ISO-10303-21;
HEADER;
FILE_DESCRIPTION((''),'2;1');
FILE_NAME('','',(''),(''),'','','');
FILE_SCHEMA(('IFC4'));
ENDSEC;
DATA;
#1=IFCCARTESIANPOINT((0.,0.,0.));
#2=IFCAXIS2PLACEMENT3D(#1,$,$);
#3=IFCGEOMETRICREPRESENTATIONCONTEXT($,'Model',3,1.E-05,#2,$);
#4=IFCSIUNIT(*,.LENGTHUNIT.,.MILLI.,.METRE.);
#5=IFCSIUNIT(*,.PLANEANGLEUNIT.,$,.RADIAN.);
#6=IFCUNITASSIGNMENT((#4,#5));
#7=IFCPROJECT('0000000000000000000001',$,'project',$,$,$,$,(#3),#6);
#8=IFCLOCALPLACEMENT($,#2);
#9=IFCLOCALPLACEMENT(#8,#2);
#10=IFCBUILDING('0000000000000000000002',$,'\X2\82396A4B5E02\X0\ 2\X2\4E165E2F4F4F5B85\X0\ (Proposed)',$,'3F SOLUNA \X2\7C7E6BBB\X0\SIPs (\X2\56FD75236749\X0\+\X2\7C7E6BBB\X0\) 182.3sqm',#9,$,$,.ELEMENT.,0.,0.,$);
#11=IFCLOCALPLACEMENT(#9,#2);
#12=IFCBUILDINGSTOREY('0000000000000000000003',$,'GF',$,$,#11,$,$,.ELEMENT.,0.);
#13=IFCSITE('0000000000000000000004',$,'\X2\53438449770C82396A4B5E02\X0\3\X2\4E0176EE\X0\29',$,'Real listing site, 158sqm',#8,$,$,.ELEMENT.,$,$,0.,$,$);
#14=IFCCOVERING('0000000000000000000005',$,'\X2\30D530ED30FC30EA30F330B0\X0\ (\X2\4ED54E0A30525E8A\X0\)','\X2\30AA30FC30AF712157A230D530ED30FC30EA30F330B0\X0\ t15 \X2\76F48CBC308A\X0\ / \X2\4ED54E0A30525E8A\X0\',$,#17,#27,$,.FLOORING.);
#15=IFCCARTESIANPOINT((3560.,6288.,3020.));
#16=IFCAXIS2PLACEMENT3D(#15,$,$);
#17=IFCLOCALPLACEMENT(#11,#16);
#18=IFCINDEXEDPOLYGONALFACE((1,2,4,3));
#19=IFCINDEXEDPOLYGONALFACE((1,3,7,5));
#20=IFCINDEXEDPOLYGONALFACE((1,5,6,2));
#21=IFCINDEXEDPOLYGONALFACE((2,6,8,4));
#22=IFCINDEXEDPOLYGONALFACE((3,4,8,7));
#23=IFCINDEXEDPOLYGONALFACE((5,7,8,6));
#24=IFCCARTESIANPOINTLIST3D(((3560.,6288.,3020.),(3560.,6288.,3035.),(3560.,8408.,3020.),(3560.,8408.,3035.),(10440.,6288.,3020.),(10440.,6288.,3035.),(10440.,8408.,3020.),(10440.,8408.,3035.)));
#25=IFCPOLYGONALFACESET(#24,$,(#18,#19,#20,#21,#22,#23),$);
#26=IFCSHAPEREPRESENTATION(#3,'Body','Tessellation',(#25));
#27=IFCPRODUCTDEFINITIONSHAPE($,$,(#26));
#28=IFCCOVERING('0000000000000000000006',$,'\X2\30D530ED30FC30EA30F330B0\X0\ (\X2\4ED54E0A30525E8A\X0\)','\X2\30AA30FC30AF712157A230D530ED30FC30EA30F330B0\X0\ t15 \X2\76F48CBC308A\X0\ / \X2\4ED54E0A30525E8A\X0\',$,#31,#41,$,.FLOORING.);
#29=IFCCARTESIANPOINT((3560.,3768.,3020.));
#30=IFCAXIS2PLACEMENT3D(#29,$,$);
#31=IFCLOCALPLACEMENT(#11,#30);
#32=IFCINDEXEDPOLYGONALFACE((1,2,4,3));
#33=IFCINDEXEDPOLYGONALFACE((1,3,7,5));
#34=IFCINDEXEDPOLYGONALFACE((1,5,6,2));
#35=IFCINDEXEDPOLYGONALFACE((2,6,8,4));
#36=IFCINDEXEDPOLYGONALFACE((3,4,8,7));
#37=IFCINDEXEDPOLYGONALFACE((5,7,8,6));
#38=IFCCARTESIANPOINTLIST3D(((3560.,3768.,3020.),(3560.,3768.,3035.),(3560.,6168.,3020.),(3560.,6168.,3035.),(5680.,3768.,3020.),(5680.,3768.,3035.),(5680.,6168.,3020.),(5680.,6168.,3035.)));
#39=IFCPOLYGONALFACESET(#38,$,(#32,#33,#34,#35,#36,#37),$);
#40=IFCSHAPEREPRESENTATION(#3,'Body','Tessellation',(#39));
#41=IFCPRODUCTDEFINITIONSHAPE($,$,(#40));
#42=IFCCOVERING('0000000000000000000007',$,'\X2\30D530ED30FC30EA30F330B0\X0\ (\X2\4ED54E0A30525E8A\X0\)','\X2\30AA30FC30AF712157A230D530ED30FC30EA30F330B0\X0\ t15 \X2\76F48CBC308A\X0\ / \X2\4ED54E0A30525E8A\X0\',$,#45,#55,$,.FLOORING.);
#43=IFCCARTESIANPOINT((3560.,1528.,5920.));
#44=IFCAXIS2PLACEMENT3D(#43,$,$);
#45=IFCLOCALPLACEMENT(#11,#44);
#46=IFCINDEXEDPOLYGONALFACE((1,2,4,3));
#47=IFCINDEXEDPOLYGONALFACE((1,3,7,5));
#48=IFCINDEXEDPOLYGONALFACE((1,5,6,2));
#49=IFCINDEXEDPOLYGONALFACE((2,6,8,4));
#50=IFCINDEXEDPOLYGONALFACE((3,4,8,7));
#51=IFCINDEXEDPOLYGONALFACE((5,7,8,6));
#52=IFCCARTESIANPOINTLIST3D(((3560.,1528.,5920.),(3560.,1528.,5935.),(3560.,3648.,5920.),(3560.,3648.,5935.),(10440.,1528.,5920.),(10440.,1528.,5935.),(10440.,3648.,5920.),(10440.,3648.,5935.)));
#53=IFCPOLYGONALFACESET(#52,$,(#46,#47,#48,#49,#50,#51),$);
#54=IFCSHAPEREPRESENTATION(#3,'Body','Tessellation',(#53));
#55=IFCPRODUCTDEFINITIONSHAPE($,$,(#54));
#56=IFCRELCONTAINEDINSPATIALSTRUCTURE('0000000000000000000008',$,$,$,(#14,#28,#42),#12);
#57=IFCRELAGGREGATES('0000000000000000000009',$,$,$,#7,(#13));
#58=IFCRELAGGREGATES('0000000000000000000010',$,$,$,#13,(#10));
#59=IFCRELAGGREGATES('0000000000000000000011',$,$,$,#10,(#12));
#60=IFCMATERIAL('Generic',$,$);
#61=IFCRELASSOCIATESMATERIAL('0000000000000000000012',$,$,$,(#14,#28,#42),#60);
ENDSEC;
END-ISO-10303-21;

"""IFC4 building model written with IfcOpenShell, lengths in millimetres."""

from ifc_helpers import new_model, si_unit, frame, frame_2d, origin, place, context, project, spatial, rectangle, extrude, material, element, save


model = new_model("IFC4")

# Units and contexts
model_context = context("Model", 3, precision=1e-05, world=origin())
ifc_project = project(units=[si_unit("LENGTHUNIT", "METRE", prefix="MILLI"), si_unit("PLANEANGLEUNIT", "RADIAN")], contexts=[model_context])

# Site, building, storey
site_placement = place(None, origin())
site = spatial("IfcSite", under=ifc_project, at=site_placement, Name="千葉県船橋市3丁目29", ObjectType="Real listing site, 158sqm", CompositionType="ELEMENT", RefElevation=0.0)
building_placement = place(site_placement, origin())
building = spatial("IfcBuilding", under=site, at=building_placement, Name="船橋市 2世帯住宅 (Proposed)", ObjectType="3F SOLUNA 籾殻SIPs (国産杉+籾殻) 182.3sqm", CompositionType="ELEMENT", ElevationOfRefHeight=0.0, ElevationOfTerrain=0.0)
storey_placement = place(building_placement, origin())
storey = spatial("IfcBuildingStorey", under=building, at=storey_placement, Name="GF", CompositionType="ELEMENT", Elevation=0.0)

# Shared definitions
ifc_material_1 = material(Name="Generic")

# Coverings
covering_1_placement = place(storey_placement, frame((3560.0, 6288.0, 3020.0)))
element("IfcCovering", 1, at=covering_1_placement, inside=storey, material=ifc_material_1, Name="フローリング (仕上げ床)", Description="オーク無垢フローリング t15 直貼り / 仕上げ床", PredefinedType="FLOORING", context=model_context, shape_type="SweptSolid", body=[
    extrude(rectangle(XDim=6880.0, YDim=2120.0, at=frame_2d((3440.0, 1060.0))), frame((3560.0, 6288.0, 3020.0)), (0.0, 0.0, 1.0), 15.0),
])
covering_2_placement = place(storey_placement, frame((3560.0, 3768.0, 3020.0)))
element("IfcCovering", 2, at=covering_2_placement, inside=storey, material=ifc_material_1, Name="フローリング (仕上げ床)", Description="オーク無垢フローリング t15 直貼り / 仕上げ床", PredefinedType="FLOORING", context=model_context, shape_type="SweptSolid", body=[
    extrude(rectangle(XDim=2120.0, YDim=2400.0, at=frame_2d((1060.0, 1200.0))), frame((3560.0, 3768.0, 3020.0)), (0.0, 0.0, 1.0), 15.0),
])
covering_3_placement = place(storey_placement, frame((3560.0, 1528.0, 5920.0)))
element("IfcCovering", 3, at=covering_3_placement, inside=storey, material=ifc_material_1, Name="フローリング (仕上げ床)", Description="オーク無垢フローリング t15 直貼り / 仕上げ床", PredefinedType="FLOORING", context=model_context, shape_type="SweptSolid", body=[
    extrude(rectangle(XDim=6880.0, YDim=2120.0, at=frame_2d((3440.0, 1060.0))), frame((3560.0, 1528.0, 5920.0)), (0.0, 0.0, 1.0), 15.0),
])

save(model, "model.ifc")
